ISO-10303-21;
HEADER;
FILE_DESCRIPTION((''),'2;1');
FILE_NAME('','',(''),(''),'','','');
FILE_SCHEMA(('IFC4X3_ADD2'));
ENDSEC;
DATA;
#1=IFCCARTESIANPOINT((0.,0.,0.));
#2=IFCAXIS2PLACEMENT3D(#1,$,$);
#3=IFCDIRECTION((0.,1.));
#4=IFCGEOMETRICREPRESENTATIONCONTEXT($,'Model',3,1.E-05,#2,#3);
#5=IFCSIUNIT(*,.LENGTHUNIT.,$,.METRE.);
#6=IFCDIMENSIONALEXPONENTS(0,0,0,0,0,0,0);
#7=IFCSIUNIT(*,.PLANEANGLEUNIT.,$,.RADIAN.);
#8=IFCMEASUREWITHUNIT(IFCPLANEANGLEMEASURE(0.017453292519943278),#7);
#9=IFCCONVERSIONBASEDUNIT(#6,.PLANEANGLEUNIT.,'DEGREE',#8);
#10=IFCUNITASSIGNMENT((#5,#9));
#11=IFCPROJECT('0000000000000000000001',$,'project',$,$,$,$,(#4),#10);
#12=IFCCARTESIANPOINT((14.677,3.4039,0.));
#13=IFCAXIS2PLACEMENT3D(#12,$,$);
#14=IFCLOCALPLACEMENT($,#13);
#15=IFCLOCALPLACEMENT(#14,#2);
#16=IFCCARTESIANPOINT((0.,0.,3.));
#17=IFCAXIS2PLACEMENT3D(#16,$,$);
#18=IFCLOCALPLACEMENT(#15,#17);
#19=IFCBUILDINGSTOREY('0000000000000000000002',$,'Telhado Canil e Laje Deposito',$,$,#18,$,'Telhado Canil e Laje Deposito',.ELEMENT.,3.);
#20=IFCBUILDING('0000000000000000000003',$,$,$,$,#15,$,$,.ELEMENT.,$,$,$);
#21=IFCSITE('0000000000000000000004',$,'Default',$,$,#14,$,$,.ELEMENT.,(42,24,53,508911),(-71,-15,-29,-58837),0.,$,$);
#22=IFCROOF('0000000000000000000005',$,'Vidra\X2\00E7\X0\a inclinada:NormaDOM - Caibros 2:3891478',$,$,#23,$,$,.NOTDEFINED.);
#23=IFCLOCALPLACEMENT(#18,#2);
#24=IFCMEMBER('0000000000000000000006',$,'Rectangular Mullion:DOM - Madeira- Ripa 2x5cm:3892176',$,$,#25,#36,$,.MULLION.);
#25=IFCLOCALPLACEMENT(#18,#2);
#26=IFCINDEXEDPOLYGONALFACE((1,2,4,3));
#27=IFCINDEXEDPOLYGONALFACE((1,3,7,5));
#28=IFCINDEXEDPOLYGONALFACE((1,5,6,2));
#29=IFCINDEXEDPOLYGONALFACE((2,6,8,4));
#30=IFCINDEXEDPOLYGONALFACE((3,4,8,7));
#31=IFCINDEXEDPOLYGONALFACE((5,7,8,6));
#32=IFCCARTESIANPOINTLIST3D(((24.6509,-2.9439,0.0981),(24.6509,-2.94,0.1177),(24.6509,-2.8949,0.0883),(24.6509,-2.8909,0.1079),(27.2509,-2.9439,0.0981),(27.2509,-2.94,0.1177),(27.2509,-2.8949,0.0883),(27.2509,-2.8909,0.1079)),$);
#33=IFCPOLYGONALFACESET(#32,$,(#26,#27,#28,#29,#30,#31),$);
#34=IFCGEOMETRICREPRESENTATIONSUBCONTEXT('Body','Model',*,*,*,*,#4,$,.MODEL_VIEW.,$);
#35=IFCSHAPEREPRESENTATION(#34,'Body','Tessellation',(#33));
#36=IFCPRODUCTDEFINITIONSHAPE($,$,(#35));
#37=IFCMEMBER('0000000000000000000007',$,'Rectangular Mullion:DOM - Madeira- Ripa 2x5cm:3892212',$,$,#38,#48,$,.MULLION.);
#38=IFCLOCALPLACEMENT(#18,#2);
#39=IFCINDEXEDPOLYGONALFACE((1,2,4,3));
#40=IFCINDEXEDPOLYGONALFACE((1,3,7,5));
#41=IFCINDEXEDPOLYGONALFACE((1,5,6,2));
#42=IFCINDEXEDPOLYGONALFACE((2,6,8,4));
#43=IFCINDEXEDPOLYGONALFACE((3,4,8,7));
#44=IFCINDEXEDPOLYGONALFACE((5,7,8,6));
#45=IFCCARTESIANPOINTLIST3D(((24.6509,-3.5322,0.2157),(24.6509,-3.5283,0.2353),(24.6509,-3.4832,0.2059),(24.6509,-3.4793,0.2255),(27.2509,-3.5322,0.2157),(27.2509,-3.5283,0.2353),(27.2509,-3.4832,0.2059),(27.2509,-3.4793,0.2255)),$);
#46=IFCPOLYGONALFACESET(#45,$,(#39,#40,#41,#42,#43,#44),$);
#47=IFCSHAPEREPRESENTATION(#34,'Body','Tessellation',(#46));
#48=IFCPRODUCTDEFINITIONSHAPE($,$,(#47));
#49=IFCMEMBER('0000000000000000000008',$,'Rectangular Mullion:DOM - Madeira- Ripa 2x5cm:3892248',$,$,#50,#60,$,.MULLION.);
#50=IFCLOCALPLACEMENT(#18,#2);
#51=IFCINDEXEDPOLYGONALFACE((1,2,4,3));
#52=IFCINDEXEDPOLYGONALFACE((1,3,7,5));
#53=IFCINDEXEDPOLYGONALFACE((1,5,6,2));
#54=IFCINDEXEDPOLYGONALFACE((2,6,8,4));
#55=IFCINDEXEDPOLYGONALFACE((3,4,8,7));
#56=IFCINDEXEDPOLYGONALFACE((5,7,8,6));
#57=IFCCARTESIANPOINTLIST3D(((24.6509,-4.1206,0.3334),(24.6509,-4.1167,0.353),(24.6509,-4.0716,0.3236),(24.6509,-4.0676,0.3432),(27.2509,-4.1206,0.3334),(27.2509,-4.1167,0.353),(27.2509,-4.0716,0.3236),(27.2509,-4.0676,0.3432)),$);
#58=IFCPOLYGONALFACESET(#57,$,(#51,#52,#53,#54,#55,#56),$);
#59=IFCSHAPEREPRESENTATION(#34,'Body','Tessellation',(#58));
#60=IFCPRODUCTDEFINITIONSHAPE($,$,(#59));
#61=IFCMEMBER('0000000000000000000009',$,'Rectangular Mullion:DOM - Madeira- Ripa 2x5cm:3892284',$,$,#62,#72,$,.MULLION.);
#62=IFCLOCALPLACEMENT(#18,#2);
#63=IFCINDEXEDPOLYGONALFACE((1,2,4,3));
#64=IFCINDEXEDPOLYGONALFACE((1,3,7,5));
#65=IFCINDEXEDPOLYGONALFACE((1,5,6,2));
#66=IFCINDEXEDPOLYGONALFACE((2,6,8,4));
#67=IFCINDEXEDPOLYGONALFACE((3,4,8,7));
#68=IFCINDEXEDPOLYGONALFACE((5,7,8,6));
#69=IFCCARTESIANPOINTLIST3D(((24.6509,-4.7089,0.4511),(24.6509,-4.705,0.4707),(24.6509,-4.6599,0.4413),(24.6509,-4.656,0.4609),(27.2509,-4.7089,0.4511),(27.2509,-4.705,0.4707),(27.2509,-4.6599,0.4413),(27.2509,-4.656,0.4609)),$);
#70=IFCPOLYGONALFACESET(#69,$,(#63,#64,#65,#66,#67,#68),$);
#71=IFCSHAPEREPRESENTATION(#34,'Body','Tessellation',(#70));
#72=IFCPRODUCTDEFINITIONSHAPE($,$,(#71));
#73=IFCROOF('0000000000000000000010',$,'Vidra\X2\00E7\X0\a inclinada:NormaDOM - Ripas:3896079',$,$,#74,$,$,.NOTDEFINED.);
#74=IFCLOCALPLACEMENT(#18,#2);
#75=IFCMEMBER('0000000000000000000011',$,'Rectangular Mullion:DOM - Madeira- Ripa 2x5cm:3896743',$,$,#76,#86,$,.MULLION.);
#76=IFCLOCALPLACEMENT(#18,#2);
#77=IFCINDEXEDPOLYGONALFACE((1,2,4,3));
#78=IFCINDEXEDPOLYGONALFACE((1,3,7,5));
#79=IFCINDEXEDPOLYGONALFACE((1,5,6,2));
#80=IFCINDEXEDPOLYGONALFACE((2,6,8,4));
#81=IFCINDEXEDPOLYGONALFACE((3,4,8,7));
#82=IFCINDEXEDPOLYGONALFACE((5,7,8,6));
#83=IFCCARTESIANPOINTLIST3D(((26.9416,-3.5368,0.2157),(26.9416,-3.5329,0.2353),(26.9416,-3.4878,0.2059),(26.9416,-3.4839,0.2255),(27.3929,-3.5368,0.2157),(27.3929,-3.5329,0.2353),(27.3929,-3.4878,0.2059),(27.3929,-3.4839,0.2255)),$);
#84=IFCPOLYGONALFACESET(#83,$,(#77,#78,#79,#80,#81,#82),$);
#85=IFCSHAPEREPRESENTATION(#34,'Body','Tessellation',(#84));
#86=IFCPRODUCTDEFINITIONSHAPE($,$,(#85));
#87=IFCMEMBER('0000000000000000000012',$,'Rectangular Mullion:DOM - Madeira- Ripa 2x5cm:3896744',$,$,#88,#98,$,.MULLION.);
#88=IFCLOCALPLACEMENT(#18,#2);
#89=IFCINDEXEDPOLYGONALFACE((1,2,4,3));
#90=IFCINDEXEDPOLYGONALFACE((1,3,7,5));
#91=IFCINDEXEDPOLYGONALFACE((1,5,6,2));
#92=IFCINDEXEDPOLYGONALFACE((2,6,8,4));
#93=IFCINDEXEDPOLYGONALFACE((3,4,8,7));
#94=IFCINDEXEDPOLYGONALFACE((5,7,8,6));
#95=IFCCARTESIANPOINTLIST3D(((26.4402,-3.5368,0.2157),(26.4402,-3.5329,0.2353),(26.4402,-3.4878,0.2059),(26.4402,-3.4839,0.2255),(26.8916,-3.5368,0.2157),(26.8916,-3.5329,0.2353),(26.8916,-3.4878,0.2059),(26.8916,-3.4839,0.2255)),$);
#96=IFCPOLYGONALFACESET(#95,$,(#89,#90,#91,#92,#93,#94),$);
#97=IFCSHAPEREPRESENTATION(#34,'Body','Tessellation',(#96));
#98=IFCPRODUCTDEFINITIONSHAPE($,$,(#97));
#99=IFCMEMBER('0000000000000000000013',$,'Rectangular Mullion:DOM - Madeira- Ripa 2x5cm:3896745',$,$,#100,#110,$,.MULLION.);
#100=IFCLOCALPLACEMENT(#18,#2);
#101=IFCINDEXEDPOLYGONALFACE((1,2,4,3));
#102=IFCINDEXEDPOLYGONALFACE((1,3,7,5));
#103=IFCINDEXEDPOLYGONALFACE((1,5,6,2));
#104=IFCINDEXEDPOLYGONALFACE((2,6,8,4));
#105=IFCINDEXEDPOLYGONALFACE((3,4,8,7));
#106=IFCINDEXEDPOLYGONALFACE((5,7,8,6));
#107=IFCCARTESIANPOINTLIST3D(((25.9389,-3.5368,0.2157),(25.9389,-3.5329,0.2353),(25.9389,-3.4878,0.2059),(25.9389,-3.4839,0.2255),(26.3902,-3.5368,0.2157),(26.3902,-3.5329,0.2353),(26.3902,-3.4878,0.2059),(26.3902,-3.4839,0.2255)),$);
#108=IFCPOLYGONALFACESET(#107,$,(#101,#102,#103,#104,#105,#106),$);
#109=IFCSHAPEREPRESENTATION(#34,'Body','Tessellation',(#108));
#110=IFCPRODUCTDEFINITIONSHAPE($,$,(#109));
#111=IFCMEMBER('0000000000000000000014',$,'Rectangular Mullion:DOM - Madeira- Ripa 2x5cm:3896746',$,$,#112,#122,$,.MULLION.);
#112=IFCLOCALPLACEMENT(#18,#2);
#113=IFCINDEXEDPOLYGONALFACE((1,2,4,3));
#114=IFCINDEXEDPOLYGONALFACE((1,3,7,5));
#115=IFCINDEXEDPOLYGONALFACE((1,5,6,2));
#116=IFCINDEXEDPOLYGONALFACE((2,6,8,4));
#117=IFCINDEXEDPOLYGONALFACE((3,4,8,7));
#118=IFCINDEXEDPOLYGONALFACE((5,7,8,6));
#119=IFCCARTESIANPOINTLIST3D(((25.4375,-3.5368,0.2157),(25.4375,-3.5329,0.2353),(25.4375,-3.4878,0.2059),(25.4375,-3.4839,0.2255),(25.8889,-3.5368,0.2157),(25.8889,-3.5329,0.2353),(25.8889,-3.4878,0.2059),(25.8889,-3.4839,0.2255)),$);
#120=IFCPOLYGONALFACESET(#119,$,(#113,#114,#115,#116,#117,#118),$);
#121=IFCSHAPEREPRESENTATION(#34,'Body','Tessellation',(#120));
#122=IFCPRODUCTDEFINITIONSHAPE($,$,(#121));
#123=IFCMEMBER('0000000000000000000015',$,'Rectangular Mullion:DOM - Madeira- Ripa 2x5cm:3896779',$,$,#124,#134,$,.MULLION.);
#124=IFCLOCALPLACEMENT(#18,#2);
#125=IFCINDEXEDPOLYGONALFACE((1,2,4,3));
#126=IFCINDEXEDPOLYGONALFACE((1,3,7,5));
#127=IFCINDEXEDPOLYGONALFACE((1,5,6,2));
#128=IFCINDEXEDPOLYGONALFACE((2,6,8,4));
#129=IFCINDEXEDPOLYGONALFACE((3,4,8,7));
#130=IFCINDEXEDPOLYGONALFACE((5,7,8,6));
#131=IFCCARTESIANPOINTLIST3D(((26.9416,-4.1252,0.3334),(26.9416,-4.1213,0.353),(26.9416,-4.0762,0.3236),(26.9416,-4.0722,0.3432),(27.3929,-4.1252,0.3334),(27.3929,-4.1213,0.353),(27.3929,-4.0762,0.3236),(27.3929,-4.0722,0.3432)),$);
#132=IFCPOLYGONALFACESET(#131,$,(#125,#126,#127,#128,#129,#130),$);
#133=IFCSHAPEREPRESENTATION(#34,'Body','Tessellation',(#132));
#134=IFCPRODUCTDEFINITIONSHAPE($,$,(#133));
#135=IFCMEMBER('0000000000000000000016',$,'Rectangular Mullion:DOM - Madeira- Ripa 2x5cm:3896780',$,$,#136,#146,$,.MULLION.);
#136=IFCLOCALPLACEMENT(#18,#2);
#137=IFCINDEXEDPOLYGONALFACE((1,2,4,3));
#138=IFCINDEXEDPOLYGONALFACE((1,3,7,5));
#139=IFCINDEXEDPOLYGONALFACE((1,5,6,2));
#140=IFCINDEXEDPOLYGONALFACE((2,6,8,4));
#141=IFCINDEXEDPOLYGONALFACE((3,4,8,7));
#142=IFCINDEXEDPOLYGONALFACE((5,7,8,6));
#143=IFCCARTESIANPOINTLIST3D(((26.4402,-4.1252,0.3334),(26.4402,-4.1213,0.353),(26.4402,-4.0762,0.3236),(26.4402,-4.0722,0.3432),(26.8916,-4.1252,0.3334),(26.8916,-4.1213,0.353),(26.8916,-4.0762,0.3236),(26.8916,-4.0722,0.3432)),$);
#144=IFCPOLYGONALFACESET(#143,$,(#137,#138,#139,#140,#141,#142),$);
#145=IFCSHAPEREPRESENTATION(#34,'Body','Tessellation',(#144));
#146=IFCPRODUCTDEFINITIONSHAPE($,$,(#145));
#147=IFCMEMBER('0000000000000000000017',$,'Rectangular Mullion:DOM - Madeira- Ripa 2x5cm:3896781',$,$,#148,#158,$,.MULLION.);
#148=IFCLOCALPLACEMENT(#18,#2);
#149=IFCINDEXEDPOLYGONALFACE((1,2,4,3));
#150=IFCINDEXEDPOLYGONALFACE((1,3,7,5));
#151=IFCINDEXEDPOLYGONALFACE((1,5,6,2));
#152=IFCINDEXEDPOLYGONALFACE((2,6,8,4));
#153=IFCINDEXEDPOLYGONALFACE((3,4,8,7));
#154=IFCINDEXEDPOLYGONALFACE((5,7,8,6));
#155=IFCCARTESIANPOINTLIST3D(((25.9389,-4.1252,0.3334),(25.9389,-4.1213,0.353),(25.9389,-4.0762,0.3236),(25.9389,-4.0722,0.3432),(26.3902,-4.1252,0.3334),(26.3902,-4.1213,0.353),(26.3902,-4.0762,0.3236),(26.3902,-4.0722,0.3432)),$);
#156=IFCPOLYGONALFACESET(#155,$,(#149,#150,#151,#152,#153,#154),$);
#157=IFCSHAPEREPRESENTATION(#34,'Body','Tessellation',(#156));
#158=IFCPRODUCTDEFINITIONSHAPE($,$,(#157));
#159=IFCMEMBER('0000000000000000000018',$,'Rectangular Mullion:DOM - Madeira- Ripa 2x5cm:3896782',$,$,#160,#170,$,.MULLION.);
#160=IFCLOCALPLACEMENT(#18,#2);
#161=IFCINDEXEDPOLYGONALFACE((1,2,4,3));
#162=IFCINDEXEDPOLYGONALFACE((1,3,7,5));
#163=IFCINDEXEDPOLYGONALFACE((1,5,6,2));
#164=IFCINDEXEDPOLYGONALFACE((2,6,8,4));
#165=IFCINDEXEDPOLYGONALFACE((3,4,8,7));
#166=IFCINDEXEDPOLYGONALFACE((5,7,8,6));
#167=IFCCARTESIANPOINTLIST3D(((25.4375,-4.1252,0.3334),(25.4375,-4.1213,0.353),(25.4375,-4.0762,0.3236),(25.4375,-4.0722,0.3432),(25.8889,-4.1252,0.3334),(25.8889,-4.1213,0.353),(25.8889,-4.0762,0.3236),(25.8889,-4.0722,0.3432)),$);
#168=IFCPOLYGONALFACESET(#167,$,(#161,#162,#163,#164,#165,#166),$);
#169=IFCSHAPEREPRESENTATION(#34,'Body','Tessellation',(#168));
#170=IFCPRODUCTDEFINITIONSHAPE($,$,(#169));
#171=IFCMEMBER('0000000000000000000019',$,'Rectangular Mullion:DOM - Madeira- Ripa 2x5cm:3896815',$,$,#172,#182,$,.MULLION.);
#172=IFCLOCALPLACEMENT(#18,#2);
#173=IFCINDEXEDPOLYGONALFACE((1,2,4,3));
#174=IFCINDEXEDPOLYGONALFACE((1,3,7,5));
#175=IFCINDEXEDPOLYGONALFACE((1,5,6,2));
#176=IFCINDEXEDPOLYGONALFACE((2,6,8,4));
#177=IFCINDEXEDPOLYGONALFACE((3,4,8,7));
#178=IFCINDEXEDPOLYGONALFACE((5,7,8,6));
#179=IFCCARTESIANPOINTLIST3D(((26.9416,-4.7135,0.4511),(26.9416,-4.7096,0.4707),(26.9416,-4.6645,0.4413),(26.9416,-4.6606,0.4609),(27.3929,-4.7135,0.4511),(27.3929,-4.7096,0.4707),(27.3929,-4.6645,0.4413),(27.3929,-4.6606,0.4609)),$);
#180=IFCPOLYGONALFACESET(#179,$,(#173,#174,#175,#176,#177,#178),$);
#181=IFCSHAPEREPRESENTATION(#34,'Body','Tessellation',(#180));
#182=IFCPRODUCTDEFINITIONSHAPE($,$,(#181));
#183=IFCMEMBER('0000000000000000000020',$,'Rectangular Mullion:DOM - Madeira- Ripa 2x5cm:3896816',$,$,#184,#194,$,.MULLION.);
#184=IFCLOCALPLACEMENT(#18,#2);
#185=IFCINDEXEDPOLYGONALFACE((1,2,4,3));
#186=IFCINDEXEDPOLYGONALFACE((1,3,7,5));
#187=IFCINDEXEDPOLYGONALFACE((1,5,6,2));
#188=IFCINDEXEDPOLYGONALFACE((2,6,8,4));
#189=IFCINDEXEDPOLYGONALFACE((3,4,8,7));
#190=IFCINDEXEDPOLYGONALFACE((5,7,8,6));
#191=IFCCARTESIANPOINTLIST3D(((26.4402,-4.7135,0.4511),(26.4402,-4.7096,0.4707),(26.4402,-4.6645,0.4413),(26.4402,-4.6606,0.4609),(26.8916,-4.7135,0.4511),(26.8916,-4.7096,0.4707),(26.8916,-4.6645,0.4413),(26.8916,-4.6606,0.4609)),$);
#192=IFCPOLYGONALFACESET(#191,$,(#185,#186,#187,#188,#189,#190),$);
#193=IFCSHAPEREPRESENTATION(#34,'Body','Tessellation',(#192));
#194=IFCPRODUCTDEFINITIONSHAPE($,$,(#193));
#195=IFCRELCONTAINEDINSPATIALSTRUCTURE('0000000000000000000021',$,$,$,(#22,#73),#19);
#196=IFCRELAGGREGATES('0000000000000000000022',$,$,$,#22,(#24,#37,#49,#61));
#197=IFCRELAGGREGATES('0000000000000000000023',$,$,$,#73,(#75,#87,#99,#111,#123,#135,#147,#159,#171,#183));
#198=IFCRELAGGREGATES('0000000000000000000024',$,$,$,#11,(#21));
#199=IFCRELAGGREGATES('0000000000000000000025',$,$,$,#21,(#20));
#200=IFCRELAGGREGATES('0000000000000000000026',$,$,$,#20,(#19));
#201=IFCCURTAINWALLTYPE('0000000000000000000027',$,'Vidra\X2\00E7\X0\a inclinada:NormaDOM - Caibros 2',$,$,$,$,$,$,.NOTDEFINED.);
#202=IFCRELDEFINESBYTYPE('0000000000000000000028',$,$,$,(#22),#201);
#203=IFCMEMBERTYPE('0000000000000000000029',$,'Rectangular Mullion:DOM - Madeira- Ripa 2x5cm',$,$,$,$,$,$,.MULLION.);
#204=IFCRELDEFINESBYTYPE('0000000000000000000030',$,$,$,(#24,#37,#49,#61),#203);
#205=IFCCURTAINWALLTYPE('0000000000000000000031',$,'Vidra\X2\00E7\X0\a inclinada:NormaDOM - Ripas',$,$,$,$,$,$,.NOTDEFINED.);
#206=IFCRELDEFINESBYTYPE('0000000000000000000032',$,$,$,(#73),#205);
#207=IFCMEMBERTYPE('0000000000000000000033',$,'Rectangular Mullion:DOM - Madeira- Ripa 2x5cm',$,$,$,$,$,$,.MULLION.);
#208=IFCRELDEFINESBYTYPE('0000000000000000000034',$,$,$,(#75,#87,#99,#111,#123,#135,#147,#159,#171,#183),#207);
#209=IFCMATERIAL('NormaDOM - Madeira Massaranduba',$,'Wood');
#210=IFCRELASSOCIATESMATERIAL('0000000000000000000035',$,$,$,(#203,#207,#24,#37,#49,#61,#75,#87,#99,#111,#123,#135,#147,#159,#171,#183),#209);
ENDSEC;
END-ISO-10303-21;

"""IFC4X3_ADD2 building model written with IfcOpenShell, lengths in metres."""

from ifc_helpers import new_model, entity, si_unit, converted_unit, direction, frame, origin, origin_2d_with_axis, place, context, subcontext, project, spatial, rectangle, extrude, source, transform, mapped, material, material_profile, profile_set, profile_usage, type_object, type_shapes, element, aggregate, save


model = new_model("IFC4X3_ADD2")

# Units and contexts
model_context = context("Model", 3, precision=1e-05, world=origin(), true_north=direction((0.0, 1.0)))
body_context = subcontext(model_context, "Body", "Model", "MODEL_VIEW")
ifc_project = project(units=[si_unit("LENGTHUNIT", "METRE"), converted_unit("PLANEANGLEUNIT", "DEGREE", entity("IfcPlaneAngleMeasure", 0.017453292519943278), si_unit("PLANEANGLEUNIT", "RADIAN"), dimensions=[0, 0, 0, 0, 0, 0, 0])], contexts=[model_context])

# Site, building, storey
site_placement = place(None, frame((14.677, 3.4039, 0.0)))
site = spatial("IfcSite", under=ifc_project, at=site_placement, Name="Default", CompositionType="ELEMENT", RefLatitude=(42, 24, 53, 508911), RefLongitude=(-71, -15, -29, -58837), RefElevation=0.0)
building_placement = place(site_placement, origin())
building = spatial("IfcBuilding", under=site, at=building_placement, CompositionType="ELEMENT")
storey_placement = place(building_placement, frame((0.0, 0.0, 3.0)))
storey = spatial("IfcBuildingStorey", under=building, at=storey_placement, Name="Telhado Canil e Laje Deposito", LongName="Telhado Canil e Laje Deposito", CompositionType="ELEMENT", Elevation=3.0)

# Roofs, members
curtain_wall_type_1 = type_object("IfcCurtainWallType", Name="Vidraça inclinada:NormaDOM - Caibros 2", PredefinedType="NOTDEFINED")
roof_1_placement = place(storey_placement, frame((0.0, 0.0, -3.0)))
roof_1 = element("IfcRoof", 1, at=roof_1_placement, inside=storey, type_object=curtain_wall_type_1, Name="Vidraça inclinada:NormaDOM - Caibros 2:3891478", PredefinedType="NOTDEFINED")
ifc_material = material(Name="NormaDOM - Madeira Massaranduba", Category="Wood")
ifc_material_profile_1 = material_profile(ifc_material, rectangle(XDim=0.05, YDim=0.02, at=origin_2d_with_axis()), Name="DOM - Madeira- Ripa 2x5cm")
ifc_profile_set_1 = profile_set([ifc_material_profile_1], Name="DOM - Madeira- Ripa 2x5cm")
ifc_profile_usage_1 = profile_usage(ifc_profile_set_1)
member_type_1 = type_object("IfcMemberType", Name="Rectangular Mullion:DOM - Madeira- Ripa 2x5cm", PredefinedType="MULLION", material=ifc_profile_set_1)
shared_shape_1 = source(origin(), body_context, "Body", "SweptSolid", [
    extrude(rectangle(XDim=0.05, YDim=0.02, at=origin_2d_with_axis()), frame((0.025, 0.01, -2.6), z_axis=(0.0, 0.0, 1.0), x_axis=(-1.0, 0.0, 0.0)), (0.0, 0.0, 1.0), 2.6),
])
type_shapes(member_type_1, [shared_shape_1])
member_1_placement = place(roof_1_placement, frame((27.2509, -2.8909, 3.1079), z_axis=(1.0, 0.0, 0.0), x_axis=(0.0, -0.980581, 0.196116)))
member_1 = element("IfcMember", 2, at=member_1_placement, type_object=member_type_1, material=ifc_profile_usage_1, Name="Rectangular Mullion:DOM - Madeira- Ripa 2x5cm:3892176", PredefinedType="MULLION", context=body_context, shape_type="MappedRepresentation", body=[
    mapped(shared_shape_1, transform((0.0, 0.0, 0.0), scale=1.0)),
])
member_2_placement = place(roof_1_placement, frame((27.2509, -3.4793, 3.2255), z_axis=(1.0, 0.0, 0.0), x_axis=(0.0, -0.980581, 0.196116)))
member_2 = element("IfcMember", 3, at=member_2_placement, type_object=member_type_1, material=ifc_profile_usage_1, Name="Rectangular Mullion:DOM - Madeira- Ripa 2x5cm:3892212", PredefinedType="MULLION", context=body_context, shape_type="MappedRepresentation", body=[
    mapped(shared_shape_1, transform((0.0, 0.0, 0.0), scale=1.0)),
])
member_3_placement = place(roof_1_placement, frame((27.2509, -4.0676, 3.3432), z_axis=(1.0, 0.0, 0.0), x_axis=(0.0, -0.980581, 0.196116)))
member_3 = element("IfcMember", 4, at=member_3_placement, type_object=member_type_1, material=ifc_profile_usage_1, Name="Rectangular Mullion:DOM - Madeira- Ripa 2x5cm:3892248", PredefinedType="MULLION", context=body_context, shape_type="MappedRepresentation", body=[
    mapped(shared_shape_1, transform((0.0, 0.0, 0.0), scale=1.0)),
])
member_4_placement = place(roof_1_placement, frame((27.2509, -4.656, 3.4609), z_axis=(1.0, 0.0, 0.0), x_axis=(0.0, -0.980581, 0.196116)))
member_4 = element("IfcMember", 5, at=member_4_placement, type_object=member_type_1, material=ifc_profile_usage_1, Name="Rectangular Mullion:DOM - Madeira- Ripa 2x5cm:3892284", PredefinedType="MULLION", context=body_context, shape_type="MappedRepresentation", body=[
    mapped(shared_shape_1, transform((0.0, 0.0, 0.0), scale=1.0)),
])
curtain_wall_type_2 = type_object("IfcCurtainWallType", Name="Vidraça inclinada:NormaDOM - Ripas", PredefinedType="NOTDEFINED")
roof_2_placement = place(storey_placement, frame((0.0, 0.0, -3.0)))
roof_2 = element("IfcRoof", 6, at=roof_2_placement, inside=storey, type_object=curtain_wall_type_2, Name="Vidraça inclinada:NormaDOM - Ripas:3896079", PredefinedType="NOTDEFINED")

# Members
aggregate(roof_1, [member_1, member_2, member_3, member_4])
member_type_2 = type_object("IfcMemberType", Name="Rectangular Mullion:DOM - Madeira- Ripa 2x5cm", PredefinedType="MULLION", material=ifc_profile_set_1)
shared_shape_2 = source(origin(), body_context, "Body", "SweptSolid", [
    extrude(rectangle(XDim=0.05, YDim=0.02, at=origin_2d_with_axis()), frame((0.025, 0.01, -0.4514), z_axis=(0.0, 0.0, 1.0), x_axis=(-1.0, 0.0, 0.0)), (0.0, 0.0, 1.0), 0.4514),
])
type_shapes(member_type_2, [shared_shape_2])
member_5_placement = place(roof_2_placement, frame((27.3929, -3.4839, 3.2255), z_axis=(1.0, 0.0, 0.0), x_axis=(0.0, -0.980581, 0.196116)))
member_5 = element("IfcMember", 7, at=member_5_placement, type_object=member_type_2, material=ifc_profile_usage_1, Name="Rectangular Mullion:DOM - Madeira- Ripa 2x5cm:3896743", PredefinedType="MULLION", context=body_context, shape_type="MappedRepresentation", body=[
    mapped(shared_shape_2, transform((0.0, 0.0, 0.0), scale=1.0)),
])
member_6_placement = place(roof_2_placement, frame((26.8916, -3.4839, 3.2255), z_axis=(1.0, 0.0, 0.0), x_axis=(0.0, -0.980581, 0.196116)))
member_6 = element("IfcMember", 8, at=member_6_placement, type_object=member_type_2, material=ifc_profile_usage_1, Name="Rectangular Mullion:DOM - Madeira- Ripa 2x5cm:3896744", PredefinedType="MULLION", context=body_context, shape_type="MappedRepresentation", body=[
    mapped(shared_shape_2, transform((0.0, 0.0, 0.0), scale=1.0)),
])
member_7_placement = place(roof_2_placement, frame((26.3902, -3.4839, 3.2255), z_axis=(1.0, 0.0, 0.0), x_axis=(0.0, -0.980581, 0.196116)))
member_7 = element("IfcMember", 9, at=member_7_placement, type_object=member_type_2, material=ifc_profile_usage_1, Name="Rectangular Mullion:DOM - Madeira- Ripa 2x5cm:3896745", PredefinedType="MULLION", context=body_context, shape_type="MappedRepresentation", body=[
    mapped(shared_shape_2, transform((0.0, 0.0, 0.0), scale=1.0)),
])
member_8_placement = place(roof_2_placement, frame((25.8889, -3.4839, 3.2255), z_axis=(1.0, 0.0, 0.0), x_axis=(0.0, -0.980581, 0.196116)))
member_8 = element("IfcMember", 10, at=member_8_placement, type_object=member_type_2, material=ifc_profile_usage_1, Name="Rectangular Mullion:DOM - Madeira- Ripa 2x5cm:3896746", PredefinedType="MULLION", context=body_context, shape_type="MappedRepresentation", body=[
    mapped(shared_shape_2, transform((0.0, 0.0, 0.0), scale=1.0)),
])
member_9_placement = place(roof_2_placement, frame((27.3929, -4.0722, 3.3432), z_axis=(1.0, 0.0, 0.0), x_axis=(0.0, -0.980581, 0.196116)))
member_9 = element("IfcMember", 11, at=member_9_placement, type_object=member_type_2, material=ifc_profile_usage_1, Name="Rectangular Mullion:DOM - Madeira- Ripa 2x5cm:3896779", PredefinedType="MULLION", context=body_context, shape_type="MappedRepresentation", body=[
    mapped(shared_shape_2, transform((0.0, 0.0, 0.0), scale=1.0)),
])
member_10_placement = place(roof_2_placement, frame((26.8916, -4.0722, 3.3432), z_axis=(1.0, 0.0, 0.0), x_axis=(0.0, -0.980581, 0.196116)))
member_10 = element("IfcMember", 12, at=member_10_placement, type_object=member_type_2, material=ifc_profile_usage_1, Name="Rectangular Mullion:DOM - Madeira- Ripa 2x5cm:3896780", PredefinedType="MULLION", context=body_context, shape_type="MappedRepresentation", body=[
    mapped(shared_shape_2, transform((0.0, 0.0, 0.0), scale=1.0)),
])
member_11_placement = place(roof_2_placement, frame((26.3902, -4.0722, 3.3432), z_axis=(1.0, 0.0, 0.0), x_axis=(0.0, -0.980581, 0.196116)))
member_11 = element("IfcMember", 13, at=member_11_placement, type_object=member_type_2, material=ifc_profile_usage_1, Name="Rectangular Mullion:DOM - Madeira- Ripa 2x5cm:3896781", PredefinedType="MULLION", context=body_context, shape_type="MappedRepresentation", body=[
    mapped(shared_shape_2, transform((0.0, 0.0, 0.0), scale=1.0)),
])
member_12_placement = place(roof_2_placement, frame((25.8889, -4.0722, 3.3432), z_axis=(1.0, 0.0, 0.0), x_axis=(0.0, -0.980581, 0.196116)))
member_12 = element("IfcMember", 14, at=member_12_placement, type_object=member_type_2, material=ifc_profile_usage_1, Name="Rectangular Mullion:DOM - Madeira- Ripa 2x5cm:3896782", PredefinedType="MULLION", context=body_context, shape_type="MappedRepresentation", body=[
    mapped(shared_shape_2, transform((0.0, 0.0, 0.0), scale=1.0)),
])
member_13_placement = place(roof_2_placement, frame((27.3929, -4.6606, 3.4609), z_axis=(1.0, 0.0, 0.0), x_axis=(0.0, -0.980581, 0.196116)))
member_13 = element("IfcMember", 15, at=member_13_placement, type_object=member_type_2, material=ifc_profile_usage_1, Name="Rectangular Mullion:DOM - Madeira- Ripa 2x5cm:3896815", PredefinedType="MULLION", context=body_context, shape_type="MappedRepresentation", body=[
    mapped(shared_shape_2, transform((0.0, 0.0, 0.0), scale=1.0)),
])
member_14_placement = place(roof_2_placement, frame((26.8916, -4.6606, 3.4609), z_axis=(1.0, 0.0, 0.0), x_axis=(0.0, -0.980581, 0.196116)))
member_14 = element("IfcMember", 16, at=member_14_placement, type_object=member_type_2, material=ifc_profile_usage_1, Name="Rectangular Mullion:DOM - Madeira- Ripa 2x5cm:3896816", PredefinedType="MULLION", context=body_context, shape_type="MappedRepresentation", body=[
    mapped(shared_shape_2, transform((0.0, 0.0, 0.0), scale=1.0)),
])
aggregate(roof_2, [member_5, member_6, member_7, member_8, member_9, member_10, member_11, member_12, member_13, member_14])

save(model, "model.ifc")
